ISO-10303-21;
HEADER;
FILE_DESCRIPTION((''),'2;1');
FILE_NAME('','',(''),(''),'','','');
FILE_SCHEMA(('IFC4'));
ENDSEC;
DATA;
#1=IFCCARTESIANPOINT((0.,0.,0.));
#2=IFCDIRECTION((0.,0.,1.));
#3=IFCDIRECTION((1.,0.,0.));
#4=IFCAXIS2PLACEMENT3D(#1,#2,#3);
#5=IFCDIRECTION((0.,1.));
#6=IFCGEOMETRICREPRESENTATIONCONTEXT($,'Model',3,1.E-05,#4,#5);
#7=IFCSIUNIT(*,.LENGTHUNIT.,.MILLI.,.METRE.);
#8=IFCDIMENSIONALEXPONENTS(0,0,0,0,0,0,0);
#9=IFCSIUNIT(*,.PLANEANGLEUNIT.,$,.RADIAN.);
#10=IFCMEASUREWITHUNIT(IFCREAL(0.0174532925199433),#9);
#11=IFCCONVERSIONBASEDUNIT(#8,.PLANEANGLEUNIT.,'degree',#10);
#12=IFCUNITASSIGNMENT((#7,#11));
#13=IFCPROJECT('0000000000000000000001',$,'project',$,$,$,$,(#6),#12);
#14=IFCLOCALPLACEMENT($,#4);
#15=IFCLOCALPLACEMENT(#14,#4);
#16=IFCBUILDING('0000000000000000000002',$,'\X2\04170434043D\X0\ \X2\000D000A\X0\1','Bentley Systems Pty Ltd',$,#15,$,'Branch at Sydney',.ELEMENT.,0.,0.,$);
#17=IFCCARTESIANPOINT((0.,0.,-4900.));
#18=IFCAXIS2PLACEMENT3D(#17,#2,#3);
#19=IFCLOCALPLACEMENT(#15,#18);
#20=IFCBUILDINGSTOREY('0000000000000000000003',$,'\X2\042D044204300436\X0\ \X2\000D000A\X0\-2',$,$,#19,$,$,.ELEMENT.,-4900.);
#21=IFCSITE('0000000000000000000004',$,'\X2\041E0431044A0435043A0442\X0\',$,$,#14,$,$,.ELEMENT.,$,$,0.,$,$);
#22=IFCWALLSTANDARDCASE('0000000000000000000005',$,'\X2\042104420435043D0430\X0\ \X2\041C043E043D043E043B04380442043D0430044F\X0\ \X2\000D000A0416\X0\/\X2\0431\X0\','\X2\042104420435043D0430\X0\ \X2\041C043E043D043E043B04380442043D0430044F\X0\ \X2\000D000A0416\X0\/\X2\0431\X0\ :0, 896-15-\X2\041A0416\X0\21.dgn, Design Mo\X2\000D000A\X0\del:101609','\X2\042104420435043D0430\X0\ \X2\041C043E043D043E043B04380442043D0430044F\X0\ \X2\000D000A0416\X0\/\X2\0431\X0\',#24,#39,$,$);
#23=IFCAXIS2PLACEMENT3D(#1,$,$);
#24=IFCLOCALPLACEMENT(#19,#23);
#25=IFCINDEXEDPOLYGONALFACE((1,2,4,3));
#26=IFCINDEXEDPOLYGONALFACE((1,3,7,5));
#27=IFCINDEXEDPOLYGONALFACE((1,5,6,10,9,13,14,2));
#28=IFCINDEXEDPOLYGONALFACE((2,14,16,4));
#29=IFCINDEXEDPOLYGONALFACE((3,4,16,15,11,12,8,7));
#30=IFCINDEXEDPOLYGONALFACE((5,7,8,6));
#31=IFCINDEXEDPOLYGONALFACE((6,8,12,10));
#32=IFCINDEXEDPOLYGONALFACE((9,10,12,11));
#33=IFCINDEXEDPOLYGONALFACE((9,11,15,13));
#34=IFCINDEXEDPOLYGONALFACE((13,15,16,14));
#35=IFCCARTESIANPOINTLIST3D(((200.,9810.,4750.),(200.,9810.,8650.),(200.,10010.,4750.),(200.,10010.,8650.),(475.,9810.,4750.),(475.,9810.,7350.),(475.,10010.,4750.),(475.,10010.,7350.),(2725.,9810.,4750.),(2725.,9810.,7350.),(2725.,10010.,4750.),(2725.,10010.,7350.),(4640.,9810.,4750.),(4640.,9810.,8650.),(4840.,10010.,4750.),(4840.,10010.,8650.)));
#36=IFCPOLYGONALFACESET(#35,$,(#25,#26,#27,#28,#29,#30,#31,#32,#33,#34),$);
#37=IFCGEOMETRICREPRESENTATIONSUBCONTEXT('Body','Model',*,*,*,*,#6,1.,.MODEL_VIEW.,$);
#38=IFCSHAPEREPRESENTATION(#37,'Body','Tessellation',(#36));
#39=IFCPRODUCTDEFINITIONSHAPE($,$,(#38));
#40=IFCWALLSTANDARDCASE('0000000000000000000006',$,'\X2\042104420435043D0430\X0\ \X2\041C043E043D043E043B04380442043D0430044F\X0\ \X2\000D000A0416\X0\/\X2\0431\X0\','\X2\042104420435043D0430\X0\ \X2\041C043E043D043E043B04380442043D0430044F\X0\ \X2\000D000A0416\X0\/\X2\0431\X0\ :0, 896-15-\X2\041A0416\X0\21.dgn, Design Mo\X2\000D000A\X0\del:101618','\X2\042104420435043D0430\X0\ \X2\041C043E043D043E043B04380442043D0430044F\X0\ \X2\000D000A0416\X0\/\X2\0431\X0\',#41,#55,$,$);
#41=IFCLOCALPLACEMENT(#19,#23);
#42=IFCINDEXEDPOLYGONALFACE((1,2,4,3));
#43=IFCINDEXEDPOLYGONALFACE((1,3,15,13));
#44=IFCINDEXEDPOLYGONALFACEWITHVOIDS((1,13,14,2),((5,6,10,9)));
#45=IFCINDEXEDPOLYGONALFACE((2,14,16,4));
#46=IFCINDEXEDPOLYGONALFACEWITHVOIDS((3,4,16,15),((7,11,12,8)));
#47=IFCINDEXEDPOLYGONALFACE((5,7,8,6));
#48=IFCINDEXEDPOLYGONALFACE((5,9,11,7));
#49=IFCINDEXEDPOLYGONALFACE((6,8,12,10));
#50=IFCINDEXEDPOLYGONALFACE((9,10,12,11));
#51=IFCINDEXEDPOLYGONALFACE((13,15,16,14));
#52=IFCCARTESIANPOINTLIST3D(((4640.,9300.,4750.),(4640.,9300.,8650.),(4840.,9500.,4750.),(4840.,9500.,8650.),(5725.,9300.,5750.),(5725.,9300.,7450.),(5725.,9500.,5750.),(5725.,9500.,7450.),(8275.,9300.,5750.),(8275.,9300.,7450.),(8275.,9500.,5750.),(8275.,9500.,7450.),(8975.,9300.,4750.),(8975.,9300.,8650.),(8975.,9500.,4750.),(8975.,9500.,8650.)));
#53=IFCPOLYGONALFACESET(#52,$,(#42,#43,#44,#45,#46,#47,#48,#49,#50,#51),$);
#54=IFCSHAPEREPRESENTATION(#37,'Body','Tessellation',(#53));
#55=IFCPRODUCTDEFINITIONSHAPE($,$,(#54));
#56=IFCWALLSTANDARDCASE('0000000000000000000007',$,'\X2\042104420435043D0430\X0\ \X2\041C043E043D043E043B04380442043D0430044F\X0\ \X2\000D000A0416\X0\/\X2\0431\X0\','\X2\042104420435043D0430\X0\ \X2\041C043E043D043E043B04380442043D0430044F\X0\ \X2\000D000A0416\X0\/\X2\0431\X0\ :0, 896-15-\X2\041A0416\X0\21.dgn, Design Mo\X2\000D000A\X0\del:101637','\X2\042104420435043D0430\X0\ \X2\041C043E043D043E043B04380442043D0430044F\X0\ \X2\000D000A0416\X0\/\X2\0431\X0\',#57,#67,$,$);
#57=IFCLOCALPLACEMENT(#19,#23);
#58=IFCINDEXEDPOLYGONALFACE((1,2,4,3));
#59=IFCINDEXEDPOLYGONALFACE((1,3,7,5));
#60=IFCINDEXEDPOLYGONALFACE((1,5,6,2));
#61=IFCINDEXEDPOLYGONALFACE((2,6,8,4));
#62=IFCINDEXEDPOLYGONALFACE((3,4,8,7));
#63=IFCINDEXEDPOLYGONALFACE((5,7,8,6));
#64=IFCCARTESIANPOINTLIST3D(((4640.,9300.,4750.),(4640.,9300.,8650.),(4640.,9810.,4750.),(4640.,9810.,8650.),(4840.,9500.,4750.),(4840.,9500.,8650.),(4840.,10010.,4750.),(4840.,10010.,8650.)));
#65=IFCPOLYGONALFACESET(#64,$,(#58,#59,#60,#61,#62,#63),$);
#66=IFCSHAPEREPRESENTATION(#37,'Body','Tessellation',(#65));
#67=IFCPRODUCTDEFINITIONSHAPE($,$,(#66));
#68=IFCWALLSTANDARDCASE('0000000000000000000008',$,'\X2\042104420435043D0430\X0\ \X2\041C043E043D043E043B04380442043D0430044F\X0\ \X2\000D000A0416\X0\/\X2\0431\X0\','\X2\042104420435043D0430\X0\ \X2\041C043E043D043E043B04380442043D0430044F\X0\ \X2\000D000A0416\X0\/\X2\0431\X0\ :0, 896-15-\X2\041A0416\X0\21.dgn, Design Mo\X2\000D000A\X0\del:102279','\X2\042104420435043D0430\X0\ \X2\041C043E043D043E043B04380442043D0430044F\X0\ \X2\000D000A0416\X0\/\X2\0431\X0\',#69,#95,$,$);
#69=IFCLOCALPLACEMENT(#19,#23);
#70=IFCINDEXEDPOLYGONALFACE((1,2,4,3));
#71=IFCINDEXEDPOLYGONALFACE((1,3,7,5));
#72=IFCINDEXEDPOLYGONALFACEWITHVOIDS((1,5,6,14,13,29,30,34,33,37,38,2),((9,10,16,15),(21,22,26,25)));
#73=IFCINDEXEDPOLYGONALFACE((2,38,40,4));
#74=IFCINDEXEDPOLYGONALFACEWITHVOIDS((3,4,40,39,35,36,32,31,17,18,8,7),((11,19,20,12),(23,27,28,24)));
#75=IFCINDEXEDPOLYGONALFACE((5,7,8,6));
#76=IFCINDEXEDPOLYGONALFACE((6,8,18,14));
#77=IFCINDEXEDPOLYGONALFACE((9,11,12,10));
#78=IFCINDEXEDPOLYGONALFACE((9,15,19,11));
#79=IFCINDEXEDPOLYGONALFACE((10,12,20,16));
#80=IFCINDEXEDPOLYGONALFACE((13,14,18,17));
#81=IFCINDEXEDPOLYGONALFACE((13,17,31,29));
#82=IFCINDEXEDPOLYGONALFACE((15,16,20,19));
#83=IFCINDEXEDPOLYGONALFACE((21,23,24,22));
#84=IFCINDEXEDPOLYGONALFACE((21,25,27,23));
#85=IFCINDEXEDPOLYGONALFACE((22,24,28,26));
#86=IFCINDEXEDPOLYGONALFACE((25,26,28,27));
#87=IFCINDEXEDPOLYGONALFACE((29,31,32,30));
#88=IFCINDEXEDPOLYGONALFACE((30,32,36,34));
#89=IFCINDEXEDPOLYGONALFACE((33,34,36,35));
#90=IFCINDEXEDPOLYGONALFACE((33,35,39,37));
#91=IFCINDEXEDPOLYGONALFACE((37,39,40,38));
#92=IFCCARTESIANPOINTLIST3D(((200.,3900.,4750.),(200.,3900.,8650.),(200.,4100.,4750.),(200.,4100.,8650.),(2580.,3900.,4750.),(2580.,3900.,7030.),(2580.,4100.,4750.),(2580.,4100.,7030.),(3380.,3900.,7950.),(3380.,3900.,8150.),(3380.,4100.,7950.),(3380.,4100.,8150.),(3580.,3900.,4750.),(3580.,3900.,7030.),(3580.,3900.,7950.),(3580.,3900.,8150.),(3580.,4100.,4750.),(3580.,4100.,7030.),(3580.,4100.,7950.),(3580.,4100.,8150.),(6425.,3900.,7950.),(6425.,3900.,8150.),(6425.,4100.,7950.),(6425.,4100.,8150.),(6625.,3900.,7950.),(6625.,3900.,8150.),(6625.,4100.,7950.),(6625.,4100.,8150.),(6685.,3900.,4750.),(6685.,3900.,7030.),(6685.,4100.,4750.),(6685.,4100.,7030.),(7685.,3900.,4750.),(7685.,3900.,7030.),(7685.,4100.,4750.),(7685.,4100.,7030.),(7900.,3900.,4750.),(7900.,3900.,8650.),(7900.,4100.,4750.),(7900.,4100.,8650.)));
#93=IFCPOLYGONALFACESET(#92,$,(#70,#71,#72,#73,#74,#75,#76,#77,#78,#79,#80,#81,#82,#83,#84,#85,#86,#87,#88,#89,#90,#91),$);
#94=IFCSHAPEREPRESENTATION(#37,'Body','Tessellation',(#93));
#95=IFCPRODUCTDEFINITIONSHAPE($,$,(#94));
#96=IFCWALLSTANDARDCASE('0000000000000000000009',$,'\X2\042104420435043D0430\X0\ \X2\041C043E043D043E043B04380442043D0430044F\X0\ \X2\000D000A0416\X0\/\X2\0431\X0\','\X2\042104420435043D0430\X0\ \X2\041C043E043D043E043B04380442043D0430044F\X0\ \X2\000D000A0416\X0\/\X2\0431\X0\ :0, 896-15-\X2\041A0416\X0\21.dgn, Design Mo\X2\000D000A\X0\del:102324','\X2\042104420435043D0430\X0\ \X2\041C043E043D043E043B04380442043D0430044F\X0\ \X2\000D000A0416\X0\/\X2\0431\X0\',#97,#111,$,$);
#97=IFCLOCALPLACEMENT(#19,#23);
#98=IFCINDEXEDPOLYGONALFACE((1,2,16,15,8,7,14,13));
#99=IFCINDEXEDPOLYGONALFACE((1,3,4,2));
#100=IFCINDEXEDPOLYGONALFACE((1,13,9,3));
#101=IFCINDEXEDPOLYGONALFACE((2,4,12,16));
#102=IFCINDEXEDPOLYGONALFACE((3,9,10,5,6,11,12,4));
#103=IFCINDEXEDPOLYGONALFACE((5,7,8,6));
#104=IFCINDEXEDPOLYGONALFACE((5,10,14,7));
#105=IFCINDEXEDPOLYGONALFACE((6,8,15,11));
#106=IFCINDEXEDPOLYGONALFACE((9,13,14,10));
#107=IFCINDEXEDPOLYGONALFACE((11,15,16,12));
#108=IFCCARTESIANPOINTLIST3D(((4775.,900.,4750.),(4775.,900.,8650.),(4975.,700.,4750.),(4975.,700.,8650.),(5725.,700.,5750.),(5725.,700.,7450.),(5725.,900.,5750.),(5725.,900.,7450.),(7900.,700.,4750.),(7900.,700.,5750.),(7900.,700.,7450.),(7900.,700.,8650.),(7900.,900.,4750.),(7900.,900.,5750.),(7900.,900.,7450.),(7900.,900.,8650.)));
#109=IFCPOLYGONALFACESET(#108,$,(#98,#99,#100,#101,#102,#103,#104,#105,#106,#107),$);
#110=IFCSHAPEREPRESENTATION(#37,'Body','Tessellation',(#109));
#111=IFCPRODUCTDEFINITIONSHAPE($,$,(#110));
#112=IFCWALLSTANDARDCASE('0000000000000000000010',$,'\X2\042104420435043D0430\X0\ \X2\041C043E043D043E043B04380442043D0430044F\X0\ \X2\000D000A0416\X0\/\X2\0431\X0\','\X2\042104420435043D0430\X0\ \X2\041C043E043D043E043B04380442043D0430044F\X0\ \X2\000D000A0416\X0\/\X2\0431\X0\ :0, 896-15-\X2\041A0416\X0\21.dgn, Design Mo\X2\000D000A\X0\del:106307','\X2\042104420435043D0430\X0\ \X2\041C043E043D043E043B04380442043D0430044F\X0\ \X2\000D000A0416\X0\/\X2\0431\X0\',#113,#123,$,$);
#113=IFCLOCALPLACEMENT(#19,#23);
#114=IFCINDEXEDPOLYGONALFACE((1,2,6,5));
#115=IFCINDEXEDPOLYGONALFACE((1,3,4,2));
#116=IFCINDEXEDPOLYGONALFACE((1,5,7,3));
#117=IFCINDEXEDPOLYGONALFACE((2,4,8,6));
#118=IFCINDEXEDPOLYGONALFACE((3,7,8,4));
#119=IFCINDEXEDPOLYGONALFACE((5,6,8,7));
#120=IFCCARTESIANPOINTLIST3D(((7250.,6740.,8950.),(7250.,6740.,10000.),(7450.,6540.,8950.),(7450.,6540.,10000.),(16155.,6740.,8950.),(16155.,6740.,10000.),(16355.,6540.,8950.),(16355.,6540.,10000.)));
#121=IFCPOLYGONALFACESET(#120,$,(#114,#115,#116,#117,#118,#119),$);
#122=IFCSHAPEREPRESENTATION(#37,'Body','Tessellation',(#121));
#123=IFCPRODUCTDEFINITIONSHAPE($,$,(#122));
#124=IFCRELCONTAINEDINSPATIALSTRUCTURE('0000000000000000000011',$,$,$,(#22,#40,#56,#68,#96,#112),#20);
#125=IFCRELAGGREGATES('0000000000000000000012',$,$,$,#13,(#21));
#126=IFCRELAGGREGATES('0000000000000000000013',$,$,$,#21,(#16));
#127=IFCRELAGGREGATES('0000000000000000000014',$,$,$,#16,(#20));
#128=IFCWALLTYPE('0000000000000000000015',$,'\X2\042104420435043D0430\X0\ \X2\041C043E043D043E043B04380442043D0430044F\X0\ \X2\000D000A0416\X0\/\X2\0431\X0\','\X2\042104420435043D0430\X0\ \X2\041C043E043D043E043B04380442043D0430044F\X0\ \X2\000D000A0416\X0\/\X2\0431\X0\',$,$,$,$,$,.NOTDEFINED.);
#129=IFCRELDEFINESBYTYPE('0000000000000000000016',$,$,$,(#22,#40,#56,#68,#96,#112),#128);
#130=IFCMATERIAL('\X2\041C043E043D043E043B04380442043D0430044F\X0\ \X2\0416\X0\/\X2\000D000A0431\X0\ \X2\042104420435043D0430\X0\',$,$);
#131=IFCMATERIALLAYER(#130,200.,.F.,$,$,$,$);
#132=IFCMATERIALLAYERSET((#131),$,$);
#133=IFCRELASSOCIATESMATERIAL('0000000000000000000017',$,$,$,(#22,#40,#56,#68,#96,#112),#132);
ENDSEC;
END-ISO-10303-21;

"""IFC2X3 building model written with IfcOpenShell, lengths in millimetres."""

from ifc_helpers import new_model, entity, si_unit, converted_unit, direction, frame, frame_2d, origin_with_axes, place, context, subcontext, project, spatial, polyline, rectangle, outline, extrude, material, layer, layer_set, layer_usage, type_object, element, save


model = new_model("IFC2X3")

# Units and contexts
model_context = context("Model", 3, precision=1e-05, world=origin_with_axes(), true_north=direction((0.0, 1.0)))
body_context = subcontext(model_context, "Body", "Model", "MODEL_VIEW", scale=1.0)
ifc_project = project(units=[si_unit("LENGTHUNIT", "METRE", prefix="MILLI"), converted_unit("PLANEANGLEUNIT", "degree", entity("IfcReal", 0.0174532925199433), si_unit("PLANEANGLEUNIT", "RADIAN"), dimensions=[0, 0, 0, 0, 0, 0, 0])], contexts=[model_context])

# Site, building, storey
site_placement = place(None, origin_with_axes())
site = spatial("IfcSite", under=ifc_project, at=site_placement, Name="Объект", CompositionType="ELEMENT", RefElevation=0.0)
building_placement = place(site_placement, origin_with_axes())
building = spatial("IfcBuilding", under=site, at=building_placement, Name="Здн \r\n1", Description="Bentley Systems Pty Ltd", LongName="Branch at Sydney", CompositionType="ELEMENT", ElevationOfRefHeight=0.0, ElevationOfTerrain=0.0)
storey_placement = place(building_placement, frame((0.0, 0.0, -4900.0), z_axis=(0.0, 0.0, 1.0), x_axis=(1.0, 0.0, 0.0)))
storey = spatial("IfcBuildingStorey", under=building, at=storey_placement, Name="Этаж \r\n-2", CompositionType="ELEMENT", Elevation=-4900.0)

# Shared definitions
ifc_material = material(Name="Монолитная Ж/\r\nб Стена")
wall_type = type_object("IfcWallType", Name="Стена Монолитная \r\nЖ/б", Description="Стена Монолитная \r\nЖ/б", PredefinedType="NOTDEFINED")

# Shared definitions
ifc_layer_1 = layer(ifc_material, 200.0, ventilated=False)
ifc_layer_set_1 = layer_set([ifc_layer_1])
ifc_layer_usage_1 = layer_usage(ifc_layer_set_1, "AXIS2", "POSITIVE", 0.0)

# Walls, openings
wall_1_placement = place(storey_placement, frame((200.0, 10010.0, 4750.0), z_axis=(0.0, 0.0, 1.0), x_axis=(1.0, 0.0, 0.0)))
wall_1 = element("IfcWallStandardCase", 1, at=wall_1_placement, inside=storey, type_object=wall_type, material=ifc_layer_usage_1, Name="Стена Монолитная \r\nЖ/б", Description="Стена Монолитная \r\nЖ/б :0, 896-15-КЖ21.dgn, Design Mo\r\ndel:101609", ObjectType="Стена Монолитная \r\nЖ/б", context=body_context, shape_type="SweptSolid", body=[
    extrude(outline(polyline([(4640.0, 0.0), (0.0, 0.0), (0.0, -200.0), (4440.0, -200.0), (4640.0, 0.0)])), origin_with_axes(), (0.0, 0.0, 1.0), 3900.0),
])
opening_1_placement = place(wall_1_placement, frame((275.0, -200.0, 0.0), z_axis=(0.0, 0.0, 1.0), x_axis=(1.0, 0.0, 0.0)))
element("IfcOpeningElement", 2, at=opening_1_placement, cuts=wall_1, ObjectType="Opening", context=body_context, shape_type="SweptSolid", body=[
    extrude(rectangle(XDim=2600.0, YDim=2250.0, at=frame_2d((-1125.0, 1300.0), x_axis=(0.0, -1.0))), frame((0.0, 0.0, 0.0), z_axis=(0.0, 1.0, 0.0), x_axis=(-1.0, 0.0, 0.0)), (0.0, 0.0, 1.0), 200.0),
])
wall_2_placement = place(storey_placement, frame((4640.0, 9300.0, 4750.0), z_axis=(0.0, 0.0, 1.0), x_axis=(1.0, 0.0, 0.0)))
wall_2 = element("IfcWallStandardCase", 3, at=wall_2_placement, inside=storey, type_object=wall_type, material=ifc_layer_usage_1, Name="Стена Монолитная \r\nЖ/б", Description="Стена Монолитная \r\nЖ/б :0, 896-15-КЖ21.dgn, Design Mo\r\ndel:101618", ObjectType="Стена Монолитная \r\nЖ/б", context=body_context, shape_type="SweptSolid", body=[
    extrude(outline(polyline([(200.0, 200.0), (0.0, 0.0), (4335.0, 0.0), (4335.0, 200.0), (200.0, 200.0)])), origin_with_axes(), (0.0, 0.0, 1.0), 3900.0),
])
opening_2_placement = place(wall_2_placement, frame((1085.0, 0.0, 1000.0), z_axis=(0.0, 0.0, 1.0), x_axis=(1.0, 0.0, 0.0)))
element("IfcOpeningElement", 4, at=opening_2_placement, cuts=wall_2, ObjectType="Opening", context=body_context, shape_type="SweptSolid", body=[
    extrude(rectangle(XDim=1700.0, YDim=2550.0, at=frame_2d((-1275.0, 850.0), x_axis=(0.0, -1.0))), frame((0.0, 0.0, 0.0), z_axis=(0.0, 1.0, 0.0), x_axis=(-1.0, 0.0, 0.0)), (0.0, 0.0, 1.0), 200.0),
])

# Wall
wall_3_placement = place(storey_placement, frame((4840.0, 10010.0, 4750.0), z_axis=(0.0, 0.0, 1.0), x_axis=(0.0, -1.0, 0.0)))
element("IfcWallStandardCase", 5, at=wall_3_placement, inside=storey, type_object=wall_type, material=ifc_layer_usage_1, Name="Стена Монолитная \r\nЖ/б", Description="Стена Монолитная \r\nЖ/б :0, 896-15-КЖ21.dgn, Design Mo\r\ndel:101637", ObjectType="Стена Монолитная \r\nЖ/б", context=body_context, shape_type="SweptSolid", body=[
    extrude(outline(polyline([(510.0, 0.0), (0.0, 0.0), (200.0, -200.0), (710.0, -200.0), (510.0, 0.0)])), origin_with_axes(), (0.0, 0.0, 1.0), 3900.0),
])

# Wall, openings
wall_4_placement = place(storey_placement, frame((200.0, 3900.0, 4750.0), z_axis=(0.0, 0.0, 1.0), x_axis=(1.0, 0.0, 0.0)))
wall_4 = element("IfcWallStandardCase", 6, at=wall_4_placement, inside=storey, type_object=wall_type, material=ifc_layer_usage_1, Name="Стена Монолитная \r\nЖ/б", Description="Стена Монолитная \r\nЖ/б :0, 896-15-КЖ21.dgn, Design Mo\r\ndel:102279", ObjectType="Стена Монолитная \r\nЖ/б", context=body_context, shape_type="SweptSolid", body=[
    extrude(rectangle(XDim=7700.0, YDim=200.0, at=frame_2d((3850.0, 100.0), x_axis=(1.0, 0.0))), origin_with_axes(), (0.0, 0.0, 1.0), 3900.0),
])
opening_3_placement = place(wall_4_placement, frame((2380.0, 0.0, 0.0), z_axis=(0.0, 0.0, 1.0), x_axis=(1.0, 0.0, 0.0)))
element("IfcOpeningElement", 7, at=opening_3_placement, cuts=wall_4, ObjectType="Opening", context=body_context, shape_type="SweptSolid", body=[
    extrude(rectangle(XDim=2280.0, YDim=1000.0, at=frame_2d((-500.0, 1140.0), x_axis=(0.0, -1.0))), frame((0.0, 0.0, 0.0), z_axis=(0.0, 1.0, 0.0), x_axis=(-1.0, 0.0, 0.0)), (0.0, 0.0, 1.0), 200.0),
])
opening_4_placement = place(wall_4_placement, frame((6485.0, 0.0, 0.0), z_axis=(0.0, 0.0, 1.0), x_axis=(1.0, 0.0, 0.0)))
element("IfcOpeningElement", 8, at=opening_4_placement, cuts=wall_4, ObjectType="Opening", context=body_context, shape_type="SweptSolid", body=[
    extrude(rectangle(XDim=2280.0, YDim=1000.0, at=frame_2d((-500.0, 1140.0), x_axis=(0.0, -1.0))), frame((0.0, 0.0, 0.0), z_axis=(0.0, 1.0, 0.0), x_axis=(-1.0, 0.0, 0.0)), (0.0, 0.0, 1.0), 200.0),
])
opening_5_placement = place(wall_4_placement, frame((3180.0, 0.0, 3200.0), z_axis=(0.0, 0.0, 1.0), x_axis=(1.0, 0.0, 0.0)))
element("IfcOpeningElement", 9, at=opening_5_placement, cuts=wall_4, ObjectType="Opening", context=body_context, shape_type="SweptSolid", body=[
    extrude(rectangle(XDim=200.0, YDim=200.0, at=frame_2d((-100.0, 100.0), x_axis=(0.0, -1.0))), frame((0.0, 0.0, 0.0), z_axis=(0.0, 1.0, 0.0), x_axis=(-1.0, 0.0, 0.0)), (0.0, 0.0, 1.0), 200.0),
])
opening_6_placement = place(wall_4_placement, frame((6225.0, 0.0, 3200.0), z_axis=(0.0, 0.0, 1.0), x_axis=(1.0, 0.0, 0.0)))
element("IfcOpeningElement", 10, at=opening_6_placement, cuts=wall_4, ObjectType="Opening", context=body_context, shape_type="SweptSolid", body=[
    extrude(rectangle(XDim=200.0, YDim=200.0, at=frame_2d((-100.0, 100.0), x_axis=(0.0, -1.0))), frame((0.0, 0.0, 0.0), z_axis=(0.0, 1.0, 0.0), x_axis=(-1.0, 0.0, 0.0)), (0.0, 0.0, 1.0), 200.0),
])

# Wall, opening
wall_5_placement = place(storey_placement, frame((7900.0, 700.0, 4750.0), z_axis=(0.0, 0.0, 1.0), x_axis=(-1.0, 0.000002, 0.0)))
wall_5 = element("IfcWallStandardCase", 11, at=wall_5_placement, inside=storey, type_object=wall_type, material=ifc_layer_usage_1, Name="Стена Монолитная \r\nЖ/б", Description="Стена Монолитная \r\nЖ/б :0, 896-15-КЖ21.dgn, Design Mo\r\ndel:102324", ObjectType="Стена Монолитная \r\nЖ/б", context=body_context, shape_type="SweptSolid", body=[
    extrude(outline(polyline([(2925.0, 0.0), (0.0, 0.0), (0.0, -200.0), (3125.0, -200.0), (2925.0, 0.0)])), origin_with_axes(), (0.0, 0.0, 1.0), 3900.0),
])
opening_7_placement = place(wall_5_placement, frame((-375.0, -200.0, 1000.0), z_axis=(0.0, 0.0, 1.0), x_axis=(1.0, 0.0, 0.0)))
element("IfcOpeningElement", 12, at=opening_7_placement, cuts=wall_5, ObjectType="Opening", context=body_context, shape_type="SweptSolid", body=[
    extrude(rectangle(XDim=1700.0, YDim=2550.0, at=frame_2d((-1275.0, 850.0), x_axis=(0.0, -1.0))), frame((0.0, 0.0, 0.0), z_axis=(0.0, 1.0, 0.0), x_axis=(-1.0, 0.0, 0.0)), (0.0, 0.0, 1.0), 200.0),
])

# Wall
wall_6_placement = place(storey_placement, frame((7250.0, 6740.0, 8950.0), z_axis=(0.0, 0.0, 1.0), x_axis=(1.0, 0.0, 0.0)))
element("IfcWallStandardCase", 13, at=wall_6_placement, inside=storey, type_object=wall_type, material=ifc_layer_usage_1, Name="Стена Монолитная \r\nЖ/б", Description="Стена Монолитная \r\nЖ/б :0, 896-15-КЖ21.dgn, Design Mo\r\ndel:106307", ObjectType="Стена Монолитная \r\nЖ/б", context=body_context, shape_type="SweptSolid", body=[
    extrude(outline(polyline([(8905.0, 0.0), (0.0, 0.0), (200.0, -200.0), (9105.0, -200.0), (8905.0, 0.0)])), origin_with_axes(), (0.0, 0.0, 1.0), 1050.0),
])

save(model, "model.ifc")
